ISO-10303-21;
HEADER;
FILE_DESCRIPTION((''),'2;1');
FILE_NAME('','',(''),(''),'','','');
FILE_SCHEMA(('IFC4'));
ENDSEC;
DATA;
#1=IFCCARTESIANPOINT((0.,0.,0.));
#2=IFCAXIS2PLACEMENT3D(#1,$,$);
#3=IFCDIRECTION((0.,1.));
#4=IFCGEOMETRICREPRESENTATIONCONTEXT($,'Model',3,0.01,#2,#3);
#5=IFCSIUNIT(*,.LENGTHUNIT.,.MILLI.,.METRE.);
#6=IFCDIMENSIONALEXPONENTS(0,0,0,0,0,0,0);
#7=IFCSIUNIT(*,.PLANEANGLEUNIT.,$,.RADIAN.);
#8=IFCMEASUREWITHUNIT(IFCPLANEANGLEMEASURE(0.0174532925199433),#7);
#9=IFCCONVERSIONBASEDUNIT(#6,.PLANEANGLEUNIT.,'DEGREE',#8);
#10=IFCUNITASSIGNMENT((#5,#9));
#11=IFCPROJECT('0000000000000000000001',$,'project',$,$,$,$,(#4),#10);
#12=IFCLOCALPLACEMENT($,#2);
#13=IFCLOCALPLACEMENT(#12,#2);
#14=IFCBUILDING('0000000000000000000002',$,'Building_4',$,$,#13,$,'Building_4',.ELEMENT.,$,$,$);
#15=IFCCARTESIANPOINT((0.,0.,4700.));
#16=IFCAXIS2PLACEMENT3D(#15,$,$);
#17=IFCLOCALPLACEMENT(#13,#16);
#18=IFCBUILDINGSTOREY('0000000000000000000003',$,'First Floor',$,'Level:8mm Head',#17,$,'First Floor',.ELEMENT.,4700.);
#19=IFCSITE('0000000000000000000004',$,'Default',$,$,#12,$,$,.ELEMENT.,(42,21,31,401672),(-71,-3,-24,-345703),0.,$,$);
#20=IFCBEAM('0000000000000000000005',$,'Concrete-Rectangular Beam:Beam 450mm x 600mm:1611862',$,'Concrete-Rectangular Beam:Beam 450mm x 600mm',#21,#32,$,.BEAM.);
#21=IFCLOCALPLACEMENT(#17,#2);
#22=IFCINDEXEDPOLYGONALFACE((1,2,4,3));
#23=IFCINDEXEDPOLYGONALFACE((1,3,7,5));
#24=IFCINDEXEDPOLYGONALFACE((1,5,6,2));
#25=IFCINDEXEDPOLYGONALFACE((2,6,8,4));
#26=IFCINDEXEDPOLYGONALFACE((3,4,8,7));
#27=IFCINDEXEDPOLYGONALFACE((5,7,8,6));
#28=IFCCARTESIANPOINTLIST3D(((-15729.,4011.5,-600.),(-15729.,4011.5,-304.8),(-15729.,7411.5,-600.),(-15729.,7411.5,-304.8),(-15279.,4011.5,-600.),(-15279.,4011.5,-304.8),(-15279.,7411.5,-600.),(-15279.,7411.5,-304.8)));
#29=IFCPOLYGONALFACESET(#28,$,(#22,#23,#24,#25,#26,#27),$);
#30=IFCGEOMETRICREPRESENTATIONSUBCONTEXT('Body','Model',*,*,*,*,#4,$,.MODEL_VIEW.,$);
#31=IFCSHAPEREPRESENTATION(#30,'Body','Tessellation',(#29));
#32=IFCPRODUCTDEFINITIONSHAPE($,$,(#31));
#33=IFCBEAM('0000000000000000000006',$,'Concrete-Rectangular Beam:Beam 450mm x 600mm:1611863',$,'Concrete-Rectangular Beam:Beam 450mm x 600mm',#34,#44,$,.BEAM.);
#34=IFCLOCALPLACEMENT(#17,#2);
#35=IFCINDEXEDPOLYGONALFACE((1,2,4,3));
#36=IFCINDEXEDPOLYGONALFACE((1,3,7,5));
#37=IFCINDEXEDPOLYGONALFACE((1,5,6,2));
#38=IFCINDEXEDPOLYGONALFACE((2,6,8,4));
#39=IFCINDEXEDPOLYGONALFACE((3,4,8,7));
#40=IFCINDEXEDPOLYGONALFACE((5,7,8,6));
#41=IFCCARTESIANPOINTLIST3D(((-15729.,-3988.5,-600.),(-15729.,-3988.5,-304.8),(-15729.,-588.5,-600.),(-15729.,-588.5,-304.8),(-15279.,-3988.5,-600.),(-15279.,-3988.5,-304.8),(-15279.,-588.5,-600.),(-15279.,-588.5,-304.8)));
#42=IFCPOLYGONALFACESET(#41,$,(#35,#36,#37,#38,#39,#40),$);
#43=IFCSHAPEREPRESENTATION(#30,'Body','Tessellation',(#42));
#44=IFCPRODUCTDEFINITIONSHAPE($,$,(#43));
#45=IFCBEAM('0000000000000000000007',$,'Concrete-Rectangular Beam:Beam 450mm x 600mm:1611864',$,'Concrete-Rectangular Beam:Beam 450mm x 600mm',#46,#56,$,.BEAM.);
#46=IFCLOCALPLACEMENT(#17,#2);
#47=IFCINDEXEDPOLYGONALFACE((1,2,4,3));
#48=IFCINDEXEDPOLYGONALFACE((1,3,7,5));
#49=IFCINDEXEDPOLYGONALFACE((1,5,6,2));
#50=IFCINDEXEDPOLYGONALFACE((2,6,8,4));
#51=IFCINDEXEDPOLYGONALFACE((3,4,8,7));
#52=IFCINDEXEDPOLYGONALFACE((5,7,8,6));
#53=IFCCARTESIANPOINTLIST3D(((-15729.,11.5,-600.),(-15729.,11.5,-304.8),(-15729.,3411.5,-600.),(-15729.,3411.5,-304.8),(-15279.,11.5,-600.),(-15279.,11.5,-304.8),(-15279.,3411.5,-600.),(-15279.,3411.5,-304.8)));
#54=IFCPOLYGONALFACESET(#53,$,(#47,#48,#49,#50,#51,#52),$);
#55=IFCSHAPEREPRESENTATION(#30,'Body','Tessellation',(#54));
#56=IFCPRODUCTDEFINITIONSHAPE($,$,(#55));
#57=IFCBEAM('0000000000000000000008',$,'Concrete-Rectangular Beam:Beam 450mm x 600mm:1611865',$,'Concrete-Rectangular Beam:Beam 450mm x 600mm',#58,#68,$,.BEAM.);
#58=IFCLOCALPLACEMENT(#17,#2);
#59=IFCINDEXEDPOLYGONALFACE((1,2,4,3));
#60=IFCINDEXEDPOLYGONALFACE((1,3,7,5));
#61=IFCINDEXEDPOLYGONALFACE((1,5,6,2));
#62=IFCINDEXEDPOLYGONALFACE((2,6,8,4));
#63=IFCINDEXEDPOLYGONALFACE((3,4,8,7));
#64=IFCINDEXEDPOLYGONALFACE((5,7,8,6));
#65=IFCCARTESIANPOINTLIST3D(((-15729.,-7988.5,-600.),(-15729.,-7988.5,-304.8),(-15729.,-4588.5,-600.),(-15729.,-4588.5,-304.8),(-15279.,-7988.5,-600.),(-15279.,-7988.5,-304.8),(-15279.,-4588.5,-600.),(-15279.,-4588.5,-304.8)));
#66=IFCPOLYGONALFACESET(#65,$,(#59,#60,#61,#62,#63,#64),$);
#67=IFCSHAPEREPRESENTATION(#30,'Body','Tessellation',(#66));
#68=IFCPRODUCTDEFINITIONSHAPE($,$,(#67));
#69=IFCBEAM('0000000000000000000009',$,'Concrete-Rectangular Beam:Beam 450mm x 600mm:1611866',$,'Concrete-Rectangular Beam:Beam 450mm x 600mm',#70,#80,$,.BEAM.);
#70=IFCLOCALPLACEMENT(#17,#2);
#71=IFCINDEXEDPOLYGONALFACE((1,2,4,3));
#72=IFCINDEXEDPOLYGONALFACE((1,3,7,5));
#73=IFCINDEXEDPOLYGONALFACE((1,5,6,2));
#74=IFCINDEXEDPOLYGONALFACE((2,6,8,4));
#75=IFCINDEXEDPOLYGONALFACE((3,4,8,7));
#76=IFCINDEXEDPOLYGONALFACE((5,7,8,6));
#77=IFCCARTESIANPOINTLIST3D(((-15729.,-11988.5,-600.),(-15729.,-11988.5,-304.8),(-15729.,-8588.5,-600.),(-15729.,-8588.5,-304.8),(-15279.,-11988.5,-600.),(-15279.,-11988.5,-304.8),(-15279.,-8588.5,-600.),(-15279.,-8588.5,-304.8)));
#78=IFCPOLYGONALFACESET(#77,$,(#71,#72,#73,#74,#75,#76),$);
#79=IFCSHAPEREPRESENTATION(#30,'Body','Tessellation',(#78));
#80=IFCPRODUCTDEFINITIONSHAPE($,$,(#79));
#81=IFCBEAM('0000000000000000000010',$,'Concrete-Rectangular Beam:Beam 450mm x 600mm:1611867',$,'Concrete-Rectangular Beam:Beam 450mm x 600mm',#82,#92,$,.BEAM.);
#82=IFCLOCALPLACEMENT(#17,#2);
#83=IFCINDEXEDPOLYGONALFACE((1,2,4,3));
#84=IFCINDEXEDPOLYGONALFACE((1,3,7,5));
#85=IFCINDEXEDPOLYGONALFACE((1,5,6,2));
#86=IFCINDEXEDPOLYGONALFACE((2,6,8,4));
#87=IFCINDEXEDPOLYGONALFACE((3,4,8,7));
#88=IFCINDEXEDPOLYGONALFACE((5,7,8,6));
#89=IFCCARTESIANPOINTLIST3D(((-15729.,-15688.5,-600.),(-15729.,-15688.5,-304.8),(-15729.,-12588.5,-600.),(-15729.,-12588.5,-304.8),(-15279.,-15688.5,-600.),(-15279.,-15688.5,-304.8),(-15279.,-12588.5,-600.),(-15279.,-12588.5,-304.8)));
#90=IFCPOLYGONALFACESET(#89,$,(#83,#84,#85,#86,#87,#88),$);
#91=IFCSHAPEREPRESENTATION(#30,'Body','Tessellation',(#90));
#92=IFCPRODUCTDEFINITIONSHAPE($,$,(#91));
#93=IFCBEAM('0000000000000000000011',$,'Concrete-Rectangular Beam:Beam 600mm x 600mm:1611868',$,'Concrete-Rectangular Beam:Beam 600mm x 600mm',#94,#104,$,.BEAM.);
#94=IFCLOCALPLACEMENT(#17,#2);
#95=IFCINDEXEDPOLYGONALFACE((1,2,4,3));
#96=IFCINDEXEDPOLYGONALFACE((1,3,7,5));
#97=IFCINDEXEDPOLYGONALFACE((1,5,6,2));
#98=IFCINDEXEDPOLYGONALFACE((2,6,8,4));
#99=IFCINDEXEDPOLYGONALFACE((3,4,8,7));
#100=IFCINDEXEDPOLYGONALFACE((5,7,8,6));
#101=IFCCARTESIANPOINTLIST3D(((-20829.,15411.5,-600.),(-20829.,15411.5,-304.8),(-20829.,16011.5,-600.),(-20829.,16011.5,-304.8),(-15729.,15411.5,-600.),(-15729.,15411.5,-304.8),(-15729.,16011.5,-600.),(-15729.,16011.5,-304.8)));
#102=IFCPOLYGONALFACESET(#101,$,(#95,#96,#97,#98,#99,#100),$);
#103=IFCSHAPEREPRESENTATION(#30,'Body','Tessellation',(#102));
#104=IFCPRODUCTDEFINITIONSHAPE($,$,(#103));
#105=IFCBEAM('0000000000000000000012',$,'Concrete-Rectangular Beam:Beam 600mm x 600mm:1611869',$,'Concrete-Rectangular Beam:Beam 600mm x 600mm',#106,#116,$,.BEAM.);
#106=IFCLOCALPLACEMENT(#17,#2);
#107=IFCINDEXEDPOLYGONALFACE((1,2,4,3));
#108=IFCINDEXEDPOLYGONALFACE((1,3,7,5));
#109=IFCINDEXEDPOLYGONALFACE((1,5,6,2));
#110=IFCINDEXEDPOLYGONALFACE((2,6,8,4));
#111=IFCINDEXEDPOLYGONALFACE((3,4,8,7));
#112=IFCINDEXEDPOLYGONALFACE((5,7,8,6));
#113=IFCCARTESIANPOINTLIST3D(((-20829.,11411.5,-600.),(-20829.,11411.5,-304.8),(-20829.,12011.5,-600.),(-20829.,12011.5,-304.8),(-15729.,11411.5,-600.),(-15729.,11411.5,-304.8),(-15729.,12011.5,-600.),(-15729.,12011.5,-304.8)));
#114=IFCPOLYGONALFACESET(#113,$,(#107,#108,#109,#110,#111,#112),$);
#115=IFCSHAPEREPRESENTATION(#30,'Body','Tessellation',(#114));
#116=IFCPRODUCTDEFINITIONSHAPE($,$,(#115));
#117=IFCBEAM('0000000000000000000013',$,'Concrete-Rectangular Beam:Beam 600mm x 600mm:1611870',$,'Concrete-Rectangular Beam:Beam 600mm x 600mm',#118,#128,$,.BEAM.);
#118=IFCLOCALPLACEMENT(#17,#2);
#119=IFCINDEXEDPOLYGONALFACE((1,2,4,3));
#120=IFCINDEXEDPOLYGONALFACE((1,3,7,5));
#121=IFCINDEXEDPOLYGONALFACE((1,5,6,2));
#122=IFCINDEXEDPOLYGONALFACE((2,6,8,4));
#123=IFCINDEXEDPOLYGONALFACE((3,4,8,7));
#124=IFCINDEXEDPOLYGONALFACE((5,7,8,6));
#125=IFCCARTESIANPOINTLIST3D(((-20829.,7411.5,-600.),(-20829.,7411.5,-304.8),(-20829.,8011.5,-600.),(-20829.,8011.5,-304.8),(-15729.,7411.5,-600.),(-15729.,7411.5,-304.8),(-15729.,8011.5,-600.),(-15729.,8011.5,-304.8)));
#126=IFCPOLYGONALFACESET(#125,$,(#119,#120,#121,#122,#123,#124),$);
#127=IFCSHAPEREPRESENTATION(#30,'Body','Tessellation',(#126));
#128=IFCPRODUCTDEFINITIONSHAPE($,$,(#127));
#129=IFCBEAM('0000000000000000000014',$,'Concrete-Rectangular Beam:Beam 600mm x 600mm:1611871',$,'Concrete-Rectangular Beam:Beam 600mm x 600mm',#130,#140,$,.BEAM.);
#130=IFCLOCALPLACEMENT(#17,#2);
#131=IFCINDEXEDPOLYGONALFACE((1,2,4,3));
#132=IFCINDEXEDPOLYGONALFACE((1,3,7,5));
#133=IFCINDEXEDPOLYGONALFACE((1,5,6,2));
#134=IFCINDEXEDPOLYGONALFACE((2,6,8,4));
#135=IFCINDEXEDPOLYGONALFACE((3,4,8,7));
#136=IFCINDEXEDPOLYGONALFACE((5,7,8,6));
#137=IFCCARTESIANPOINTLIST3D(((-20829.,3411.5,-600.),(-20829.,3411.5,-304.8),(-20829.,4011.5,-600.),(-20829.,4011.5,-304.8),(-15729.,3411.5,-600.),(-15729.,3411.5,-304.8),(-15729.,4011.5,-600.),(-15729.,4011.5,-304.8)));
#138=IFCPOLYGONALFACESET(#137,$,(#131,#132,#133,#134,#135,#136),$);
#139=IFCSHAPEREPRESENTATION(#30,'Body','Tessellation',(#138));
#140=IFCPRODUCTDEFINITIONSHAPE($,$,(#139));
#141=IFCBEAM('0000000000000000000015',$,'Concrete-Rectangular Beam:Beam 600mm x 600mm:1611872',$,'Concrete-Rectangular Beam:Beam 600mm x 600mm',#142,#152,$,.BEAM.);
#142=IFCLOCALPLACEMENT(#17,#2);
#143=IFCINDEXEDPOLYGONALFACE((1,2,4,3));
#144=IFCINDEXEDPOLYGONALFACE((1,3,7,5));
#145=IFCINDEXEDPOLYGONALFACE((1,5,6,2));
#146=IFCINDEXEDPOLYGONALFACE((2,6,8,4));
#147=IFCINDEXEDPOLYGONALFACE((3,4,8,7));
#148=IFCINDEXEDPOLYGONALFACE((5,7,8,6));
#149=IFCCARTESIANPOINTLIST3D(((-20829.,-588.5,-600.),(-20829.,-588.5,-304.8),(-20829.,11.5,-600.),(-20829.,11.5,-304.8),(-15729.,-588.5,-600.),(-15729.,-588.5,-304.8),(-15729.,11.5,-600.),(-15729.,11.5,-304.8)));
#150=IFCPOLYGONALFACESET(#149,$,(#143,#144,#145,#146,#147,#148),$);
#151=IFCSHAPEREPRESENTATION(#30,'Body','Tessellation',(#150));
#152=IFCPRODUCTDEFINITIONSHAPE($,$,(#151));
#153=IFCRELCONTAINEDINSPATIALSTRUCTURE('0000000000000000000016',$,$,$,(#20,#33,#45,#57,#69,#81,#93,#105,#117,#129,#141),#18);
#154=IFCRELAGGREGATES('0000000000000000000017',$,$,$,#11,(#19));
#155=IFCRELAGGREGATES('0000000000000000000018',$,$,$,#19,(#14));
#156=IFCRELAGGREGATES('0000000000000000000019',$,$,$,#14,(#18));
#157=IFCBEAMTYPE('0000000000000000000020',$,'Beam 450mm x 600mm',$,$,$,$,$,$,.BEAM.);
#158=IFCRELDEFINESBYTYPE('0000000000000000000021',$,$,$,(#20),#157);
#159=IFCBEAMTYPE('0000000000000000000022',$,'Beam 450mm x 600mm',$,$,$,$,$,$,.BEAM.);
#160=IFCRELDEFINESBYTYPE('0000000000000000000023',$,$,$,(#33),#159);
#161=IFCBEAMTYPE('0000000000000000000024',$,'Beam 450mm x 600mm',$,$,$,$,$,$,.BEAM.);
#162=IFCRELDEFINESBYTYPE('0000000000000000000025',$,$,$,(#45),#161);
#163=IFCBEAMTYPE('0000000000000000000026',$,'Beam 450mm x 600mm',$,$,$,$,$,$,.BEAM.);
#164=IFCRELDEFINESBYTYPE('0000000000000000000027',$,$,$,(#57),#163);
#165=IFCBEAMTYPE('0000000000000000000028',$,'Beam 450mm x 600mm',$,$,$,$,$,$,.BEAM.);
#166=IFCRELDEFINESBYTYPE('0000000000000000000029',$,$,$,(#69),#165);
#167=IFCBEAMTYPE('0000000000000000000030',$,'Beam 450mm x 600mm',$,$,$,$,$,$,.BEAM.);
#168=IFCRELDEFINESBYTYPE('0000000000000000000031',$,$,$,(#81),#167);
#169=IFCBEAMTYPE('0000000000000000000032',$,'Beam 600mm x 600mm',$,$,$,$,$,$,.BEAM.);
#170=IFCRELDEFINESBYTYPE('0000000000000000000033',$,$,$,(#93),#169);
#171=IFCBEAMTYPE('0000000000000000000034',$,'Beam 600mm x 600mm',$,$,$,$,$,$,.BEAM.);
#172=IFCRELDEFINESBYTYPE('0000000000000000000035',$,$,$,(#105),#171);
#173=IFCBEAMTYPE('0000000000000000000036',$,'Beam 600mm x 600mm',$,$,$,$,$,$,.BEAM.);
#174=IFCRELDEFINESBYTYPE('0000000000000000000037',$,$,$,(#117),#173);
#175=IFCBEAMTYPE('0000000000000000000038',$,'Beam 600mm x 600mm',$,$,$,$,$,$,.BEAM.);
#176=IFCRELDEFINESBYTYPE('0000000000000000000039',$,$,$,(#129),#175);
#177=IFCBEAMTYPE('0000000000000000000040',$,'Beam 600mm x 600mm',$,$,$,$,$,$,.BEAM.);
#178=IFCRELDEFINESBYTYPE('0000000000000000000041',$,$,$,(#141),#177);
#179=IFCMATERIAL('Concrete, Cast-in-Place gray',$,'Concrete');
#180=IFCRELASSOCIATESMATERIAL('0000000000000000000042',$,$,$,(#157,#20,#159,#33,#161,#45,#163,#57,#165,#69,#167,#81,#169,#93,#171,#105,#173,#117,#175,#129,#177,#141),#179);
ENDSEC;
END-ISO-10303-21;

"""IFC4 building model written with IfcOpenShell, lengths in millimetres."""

from ifc_helpers import new_model, entity, si_unit, converted_unit, direction, frame, origin, place, context, subcontext, project, spatial, indexed_curve, outline, extrude, source, transform, mapped, material, type_object, type_shapes, element, save


model = new_model("IFC4")

# Units and contexts
model_context = context("Model", 3, precision=0.01, world=origin(), true_north=direction((0.0, 1.0)))
body_context = subcontext(model_context, "Body", "Model", "MODEL_VIEW")
ifc_project = project(units=[si_unit("LENGTHUNIT", "METRE", prefix="MILLI"), converted_unit("PLANEANGLEUNIT", "DEGREE", entity("IfcPlaneAngleMeasure", 0.0174532925199433), si_unit("PLANEANGLEUNIT", "RADIAN"), dimensions=[0, 0, 0, 0, 0, 0, 0])], contexts=[model_context])

# Site, building, storey
site_placement = place(None, origin())
site = spatial("IfcSite", under=ifc_project, at=site_placement, Name="Default", CompositionType="ELEMENT", RefLatitude=(42, 21, 31, 401672), RefLongitude=(-71, -3, -24, -345703), RefElevation=0.0)
building_placement = place(site_placement, origin())
building = spatial("IfcBuilding", under=site, at=building_placement, Name="Building_4", LongName="Building_4", CompositionType="ELEMENT")
storey_placement = place(building_placement, frame((0.0, 0.0, 4700.0)))
storey = spatial("IfcBuildingStorey", under=building, at=storey_placement, Name="First Floor", ObjectType="Level:8mm Head", LongName="First Floor", CompositionType="ELEMENT", Elevation=4700.0)

# Beams
ifc_material = material(Name="Concrete, Cast-in-Place gray", Category="Concrete")
beam_type_1 = type_object("IfcBeamType", Name="Beam 450mm x 600mm", PredefinedType="BEAM", material=ifc_material)
shared_shape_1 = source(origin(), body_context, "Body", "SweptSolid", [
    extrude(outline(indexed_curve([(-225.0, -147.6), (225.0, -147.6), (225.0, 147.6), (-225.0, 147.6), (-225.0, -147.6)], self_intersect=False)), frame((-15504.0, 4011.5, 4247.6), z_axis=(0.0, 1.0, 0.0), x_axis=(-1.0, 0.0, 0.0)), (0.0, 0.0, 1.0), 3400.0),
])
type_shapes(beam_type_1, [shared_shape_1])
beam_1_placement = place(storey_placement, frame((0.0, 0.0, -4700.0)))
element("IfcBeam", 1, at=beam_1_placement, inside=storey, type_object=beam_type_1, material=ifc_material, Name="Concrete-Rectangular Beam:Beam 450mm x 600mm:1611862", ObjectType="Concrete-Rectangular Beam:Beam 450mm x 600mm", PredefinedType="BEAM", context=body_context, shape_type="MappedRepresentation", body=[
    mapped(shared_shape_1, transform((0.0, 0.0, 0.0), scale=1.0)),
])
beam_type_2 = type_object("IfcBeamType", Name="Beam 450mm x 600mm", PredefinedType="BEAM", material=ifc_material)
shared_shape_2 = source(origin(), body_context, "Body", "SweptSolid", [
    extrude(outline(indexed_curve([(-225.0, -147.6), (225.0, -147.6), (225.0, 147.6), (-225.0, 147.6), (-225.0, -147.6)], self_intersect=False)), frame((-15504.0, -588.5, 4247.6), z_axis=(0.0, -1.0, 0.0), x_axis=(-1.0, 0.0, 0.0)), (0.0, 0.0, 1.0), 3400.0),
])
type_shapes(beam_type_2, [shared_shape_2])
beam_2_placement = place(storey_placement, frame((0.0, 0.0, -4700.0)))
element("IfcBeam", 2, at=beam_2_placement, inside=storey, type_object=beam_type_2, material=ifc_material, Name="Concrete-Rectangular Beam:Beam 450mm x 600mm:1611863", ObjectType="Concrete-Rectangular Beam:Beam 450mm x 600mm", PredefinedType="BEAM", context=body_context, shape_type="MappedRepresentation", body=[
    mapped(shared_shape_2, transform((0.0, 0.0, 0.0), scale=1.0)),
])
beam_type_3 = type_object("IfcBeamType", Name="Beam 450mm x 600mm", PredefinedType="BEAM", material=ifc_material)
shared_shape_3 = source(origin(), body_context, "Body", "SweptSolid", [
    extrude(outline(indexed_curve([(-225.0, -147.6), (225.0, -147.6), (225.0, 147.6), (-225.0, 147.6), (-225.0, -147.6)], self_intersect=False)), frame((-15504.0, 11.5, 4247.6), z_axis=(0.0, 1.0, 0.0), x_axis=(-1.0, 0.0, 0.0)), (0.0, 0.0, 1.0), 3400.0),
])
type_shapes(beam_type_3, [shared_shape_3])
beam_3_placement = place(storey_placement, frame((0.0, 0.0, -4700.0)))
element("IfcBeam", 3, at=beam_3_placement, inside=storey, type_object=beam_type_3, material=ifc_material, Name="Concrete-Rectangular Beam:Beam 450mm x 600mm:1611864", ObjectType="Concrete-Rectangular Beam:Beam 450mm x 600mm", PredefinedType="BEAM", context=body_context, shape_type="MappedRepresentation", body=[
    mapped(shared_shape_3, transform((0.0, 0.0, 0.0), scale=1.0)),
])
beam_type_4 = type_object("IfcBeamType", Name="Beam 450mm x 600mm", PredefinedType="BEAM", material=ifc_material)
shared_shape_4 = source(origin(), body_context, "Body", "SweptSolid", [
    extrude(outline(indexed_curve([(-225.0, -147.6), (225.0, -147.6), (225.0, 147.6), (-225.0, 147.6), (-225.0, -147.6)], self_intersect=False)), frame((-15504.0, -4588.5, 4247.6), z_axis=(0.0, -1.0, 0.0), x_axis=(-1.0, 0.0, 0.0)), (0.0, 0.0, 1.0), 3400.0),
])
type_shapes(beam_type_4, [shared_shape_4])
beam_4_placement = place(storey_placement, frame((0.0, 0.0, -4700.0)))
element("IfcBeam", 4, at=beam_4_placement, inside=storey, type_object=beam_type_4, material=ifc_material, Name="Concrete-Rectangular Beam:Beam 450mm x 600mm:1611865", ObjectType="Concrete-Rectangular Beam:Beam 450mm x 600mm", PredefinedType="BEAM", context=body_context, shape_type="MappedRepresentation", body=[
    mapped(shared_shape_4, transform((0.0, 0.0, 0.0), scale=1.0)),
])
beam_type_5 = type_object("IfcBeamType", Name="Beam 450mm x 600mm", PredefinedType="BEAM", material=ifc_material)
shared_shape_5 = source(origin(), body_context, "Body", "SweptSolid", [
    extrude(outline(indexed_curve([(-225.0, -147.6), (225.0, -147.6), (225.0, 147.6), (-225.0, 147.6), (-225.0, -147.6)], self_intersect=False)), frame((-15504.0, -8588.5, 4247.6), z_axis=(0.0, -1.0, 0.0), x_axis=(-1.0, 0.0, 0.0)), (0.0, 0.0, 1.0), 3400.0),
])
type_shapes(beam_type_5, [shared_shape_5])
beam_5_placement = place(storey_placement, frame((0.0, 0.0, -4700.0)))
element("IfcBeam", 5, at=beam_5_placement, inside=storey, type_object=beam_type_5, material=ifc_material, Name="Concrete-Rectangular Beam:Beam 450mm x 600mm:1611866", ObjectType="Concrete-Rectangular Beam:Beam 450mm x 600mm", PredefinedType="BEAM", context=body_context, shape_type="MappedRepresentation", body=[
    mapped(shared_shape_5, transform((0.0, 0.0, 0.0), scale=1.0)),
])
beam_type_6 = type_object("IfcBeamType", Name="Beam 450mm x 600mm", PredefinedType="BEAM", material=ifc_material)
shared_shape_6 = source(origin(), body_context, "Body", "SweptSolid", [
    extrude(outline(indexed_curve([(-225.0, -147.6), (225.0, -147.6), (225.0, 147.6), (-225.0, 147.6), (-225.0, -147.6)], self_intersect=False)), frame((-15504.0, -12588.5, 4247.6), z_axis=(0.0, -1.0, 0.0), x_axis=(-1.0, 0.0, 0.0)), (0.0, 0.0, 1.0), 3100.0),
])
type_shapes(beam_type_6, [shared_shape_6])
beam_6_placement = place(storey_placement, frame((0.0, 0.0, -4700.0)))
element("IfcBeam", 6, at=beam_6_placement, inside=storey, type_object=beam_type_6, material=ifc_material, Name="Concrete-Rectangular Beam:Beam 450mm x 600mm:1611867", ObjectType="Concrete-Rectangular Beam:Beam 450mm x 600mm", PredefinedType="BEAM", context=body_context, shape_type="MappedRepresentation", body=[
    mapped(shared_shape_6, transform((0.0, 0.0, 0.0), scale=1.0)),
])
beam_type_7 = type_object("IfcBeamType", Name="Beam 600mm x 600mm", PredefinedType="BEAM", material=ifc_material)
shared_shape_7 = source(origin(), body_context, "Body", "SweptSolid", [
    extrude(outline(indexed_curve([(-147.6, -300.0), (147.6, -300.0), (147.6, 300.0), (-147.6, 300.0), (-147.6, -300.0)], self_intersect=False)), frame((-20829.0, 15711.5, 4247.6), z_axis=(1.0, 0.0, 0.0), x_axis=(0.0, 0.0, -1.0)), (0.0, 0.0, 1.0), 5100.0),
])
type_shapes(beam_type_7, [shared_shape_7])
beam_7_placement = place(storey_placement, frame((0.0, 0.0, -4700.0)))
element("IfcBeam", 7, at=beam_7_placement, inside=storey, type_object=beam_type_7, material=ifc_material, Name="Concrete-Rectangular Beam:Beam 600mm x 600mm:1611868", ObjectType="Concrete-Rectangular Beam:Beam 600mm x 600mm", PredefinedType="BEAM", context=body_context, shape_type="MappedRepresentation", body=[
    mapped(shared_shape_7, transform((0.0, 0.0, 0.0), scale=1.0)),
])
beam_type_8 = type_object("IfcBeamType", Name="Beam 600mm x 600mm", PredefinedType="BEAM", material=ifc_material)
shared_shape_8 = source(origin(), body_context, "Body", "SweptSolid", [
    extrude(outline(indexed_curve([(-147.6, -300.0), (147.6, -300.0), (147.6, 300.0), (-147.6, 300.0), (-147.6, -300.0)], self_intersect=False)), frame((-15729.0, 11711.5, 4247.6), z_axis=(-1.0, 0.0, 0.0), x_axis=(0.0, 0.0, -1.0)), (0.0, 0.0, 1.0), 5100.0),
])
type_shapes(beam_type_8, [shared_shape_8])
beam_8_placement = place(storey_placement, frame((0.0, 0.0, -4700.0)))
element("IfcBeam", 8, at=beam_8_placement, inside=storey, type_object=beam_type_8, material=ifc_material, Name="Concrete-Rectangular Beam:Beam 600mm x 600mm:1611869", ObjectType="Concrete-Rectangular Beam:Beam 600mm x 600mm", PredefinedType="BEAM", context=body_context, shape_type="MappedRepresentation", body=[
    mapped(shared_shape_8, transform((0.0, 0.0, 0.0), scale=1.0)),
])
beam_type_9 = type_object("IfcBeamType", Name="Beam 600mm x 600mm", PredefinedType="BEAM", material=ifc_material)
shared_shape_9 = source(origin(), body_context, "Body", "SweptSolid", [
    extrude(outline(indexed_curve([(-147.6, -300.0), (147.6, -300.0), (147.6, 300.0), (-147.6, 300.0), (-147.6, -300.0)], self_intersect=False)), frame((-20829.0, 7711.5, 4247.6), z_axis=(1.0, 0.0, 0.0), x_axis=(0.0, 0.0, -1.0)), (0.0, 0.0, 1.0), 5100.0),
])
type_shapes(beam_type_9, [shared_shape_9])
beam_9_placement = place(storey_placement, frame((0.0, 0.0, -4700.0)))
element("IfcBeam", 9, at=beam_9_placement, inside=storey, type_object=beam_type_9, material=ifc_material, Name="Concrete-Rectangular Beam:Beam 600mm x 600mm:1611870", ObjectType="Concrete-Rectangular Beam:Beam 600mm x 600mm", PredefinedType="BEAM", context=body_context, shape_type="MappedRepresentation", body=[
    mapped(shared_shape_9, transform((0.0, 0.0, 0.0), scale=1.0)),
])
beam_type_10 = type_object("IfcBeamType", Name="Beam 600mm x 600mm", PredefinedType="BEAM", material=ifc_material)
shared_shape_10 = source(origin(), body_context, "Body", "SweptSolid", [
    extrude(outline(indexed_curve([(-147.6, -300.0), (147.6, -300.0), (147.6, 300.0), (-147.6, 300.0), (-147.6, -300.0)], self_intersect=False)), frame((-15729.0, 3711.5, 4247.6), z_axis=(-1.0, 0.0, 0.0), x_axis=(0.0, 0.0, -1.0)), (0.0, 0.0, 1.0), 5100.0),
])
type_shapes(beam_type_10, [shared_shape_10])
beam_10_placement = place(storey_placement, frame((0.0, 0.0, -4700.0)))
element("IfcBeam", 10, at=beam_10_placement, inside=storey, type_object=beam_type_10, material=ifc_material, Name="Concrete-Rectangular Beam:Beam 600mm x 600mm:1611871", ObjectType="Concrete-Rectangular Beam:Beam 600mm x 600mm", PredefinedType="BEAM", context=body_context, shape_type="MappedRepresentation", body=[
    mapped(shared_shape_10, transform((0.0, 0.0, 0.0), scale=1.0)),
])
beam_type_11 = type_object("IfcBeamType", Name="Beam 600mm x 600mm", PredefinedType="BEAM", material=ifc_material)
shared_shape_11 = source(origin(), body_context, "Body", "SweptSolid", [
    extrude(outline(indexed_curve([(-147.6, -300.0), (147.6, -300.0), (147.6, 300.0), (-147.6, 300.0), (-147.6, -300.0)], self_intersect=False)), frame((-20829.0, -288.5, 4247.6), z_axis=(1.0, 0.0, 0.0), x_axis=(0.0, 0.0, -1.0)), (0.0, 0.0, 1.0), 5100.0),
])
type_shapes(beam_type_11, [shared_shape_11])
beam_11_placement = place(storey_placement, frame((0.0, 0.0, -4700.0)))
element("IfcBeam", 11, at=beam_11_placement, inside=storey, type_object=beam_type_11, material=ifc_material, Name="Concrete-Rectangular Beam:Beam 600mm x 600mm:1611872", ObjectType="Concrete-Rectangular Beam:Beam 600mm x 600mm", PredefinedType="BEAM", context=body_context, shape_type="MappedRepresentation", body=[
    mapped(shared_shape_11, transform((0.0, 0.0, 0.0), scale=1.0)),
])

save(model, "model.ifc")
